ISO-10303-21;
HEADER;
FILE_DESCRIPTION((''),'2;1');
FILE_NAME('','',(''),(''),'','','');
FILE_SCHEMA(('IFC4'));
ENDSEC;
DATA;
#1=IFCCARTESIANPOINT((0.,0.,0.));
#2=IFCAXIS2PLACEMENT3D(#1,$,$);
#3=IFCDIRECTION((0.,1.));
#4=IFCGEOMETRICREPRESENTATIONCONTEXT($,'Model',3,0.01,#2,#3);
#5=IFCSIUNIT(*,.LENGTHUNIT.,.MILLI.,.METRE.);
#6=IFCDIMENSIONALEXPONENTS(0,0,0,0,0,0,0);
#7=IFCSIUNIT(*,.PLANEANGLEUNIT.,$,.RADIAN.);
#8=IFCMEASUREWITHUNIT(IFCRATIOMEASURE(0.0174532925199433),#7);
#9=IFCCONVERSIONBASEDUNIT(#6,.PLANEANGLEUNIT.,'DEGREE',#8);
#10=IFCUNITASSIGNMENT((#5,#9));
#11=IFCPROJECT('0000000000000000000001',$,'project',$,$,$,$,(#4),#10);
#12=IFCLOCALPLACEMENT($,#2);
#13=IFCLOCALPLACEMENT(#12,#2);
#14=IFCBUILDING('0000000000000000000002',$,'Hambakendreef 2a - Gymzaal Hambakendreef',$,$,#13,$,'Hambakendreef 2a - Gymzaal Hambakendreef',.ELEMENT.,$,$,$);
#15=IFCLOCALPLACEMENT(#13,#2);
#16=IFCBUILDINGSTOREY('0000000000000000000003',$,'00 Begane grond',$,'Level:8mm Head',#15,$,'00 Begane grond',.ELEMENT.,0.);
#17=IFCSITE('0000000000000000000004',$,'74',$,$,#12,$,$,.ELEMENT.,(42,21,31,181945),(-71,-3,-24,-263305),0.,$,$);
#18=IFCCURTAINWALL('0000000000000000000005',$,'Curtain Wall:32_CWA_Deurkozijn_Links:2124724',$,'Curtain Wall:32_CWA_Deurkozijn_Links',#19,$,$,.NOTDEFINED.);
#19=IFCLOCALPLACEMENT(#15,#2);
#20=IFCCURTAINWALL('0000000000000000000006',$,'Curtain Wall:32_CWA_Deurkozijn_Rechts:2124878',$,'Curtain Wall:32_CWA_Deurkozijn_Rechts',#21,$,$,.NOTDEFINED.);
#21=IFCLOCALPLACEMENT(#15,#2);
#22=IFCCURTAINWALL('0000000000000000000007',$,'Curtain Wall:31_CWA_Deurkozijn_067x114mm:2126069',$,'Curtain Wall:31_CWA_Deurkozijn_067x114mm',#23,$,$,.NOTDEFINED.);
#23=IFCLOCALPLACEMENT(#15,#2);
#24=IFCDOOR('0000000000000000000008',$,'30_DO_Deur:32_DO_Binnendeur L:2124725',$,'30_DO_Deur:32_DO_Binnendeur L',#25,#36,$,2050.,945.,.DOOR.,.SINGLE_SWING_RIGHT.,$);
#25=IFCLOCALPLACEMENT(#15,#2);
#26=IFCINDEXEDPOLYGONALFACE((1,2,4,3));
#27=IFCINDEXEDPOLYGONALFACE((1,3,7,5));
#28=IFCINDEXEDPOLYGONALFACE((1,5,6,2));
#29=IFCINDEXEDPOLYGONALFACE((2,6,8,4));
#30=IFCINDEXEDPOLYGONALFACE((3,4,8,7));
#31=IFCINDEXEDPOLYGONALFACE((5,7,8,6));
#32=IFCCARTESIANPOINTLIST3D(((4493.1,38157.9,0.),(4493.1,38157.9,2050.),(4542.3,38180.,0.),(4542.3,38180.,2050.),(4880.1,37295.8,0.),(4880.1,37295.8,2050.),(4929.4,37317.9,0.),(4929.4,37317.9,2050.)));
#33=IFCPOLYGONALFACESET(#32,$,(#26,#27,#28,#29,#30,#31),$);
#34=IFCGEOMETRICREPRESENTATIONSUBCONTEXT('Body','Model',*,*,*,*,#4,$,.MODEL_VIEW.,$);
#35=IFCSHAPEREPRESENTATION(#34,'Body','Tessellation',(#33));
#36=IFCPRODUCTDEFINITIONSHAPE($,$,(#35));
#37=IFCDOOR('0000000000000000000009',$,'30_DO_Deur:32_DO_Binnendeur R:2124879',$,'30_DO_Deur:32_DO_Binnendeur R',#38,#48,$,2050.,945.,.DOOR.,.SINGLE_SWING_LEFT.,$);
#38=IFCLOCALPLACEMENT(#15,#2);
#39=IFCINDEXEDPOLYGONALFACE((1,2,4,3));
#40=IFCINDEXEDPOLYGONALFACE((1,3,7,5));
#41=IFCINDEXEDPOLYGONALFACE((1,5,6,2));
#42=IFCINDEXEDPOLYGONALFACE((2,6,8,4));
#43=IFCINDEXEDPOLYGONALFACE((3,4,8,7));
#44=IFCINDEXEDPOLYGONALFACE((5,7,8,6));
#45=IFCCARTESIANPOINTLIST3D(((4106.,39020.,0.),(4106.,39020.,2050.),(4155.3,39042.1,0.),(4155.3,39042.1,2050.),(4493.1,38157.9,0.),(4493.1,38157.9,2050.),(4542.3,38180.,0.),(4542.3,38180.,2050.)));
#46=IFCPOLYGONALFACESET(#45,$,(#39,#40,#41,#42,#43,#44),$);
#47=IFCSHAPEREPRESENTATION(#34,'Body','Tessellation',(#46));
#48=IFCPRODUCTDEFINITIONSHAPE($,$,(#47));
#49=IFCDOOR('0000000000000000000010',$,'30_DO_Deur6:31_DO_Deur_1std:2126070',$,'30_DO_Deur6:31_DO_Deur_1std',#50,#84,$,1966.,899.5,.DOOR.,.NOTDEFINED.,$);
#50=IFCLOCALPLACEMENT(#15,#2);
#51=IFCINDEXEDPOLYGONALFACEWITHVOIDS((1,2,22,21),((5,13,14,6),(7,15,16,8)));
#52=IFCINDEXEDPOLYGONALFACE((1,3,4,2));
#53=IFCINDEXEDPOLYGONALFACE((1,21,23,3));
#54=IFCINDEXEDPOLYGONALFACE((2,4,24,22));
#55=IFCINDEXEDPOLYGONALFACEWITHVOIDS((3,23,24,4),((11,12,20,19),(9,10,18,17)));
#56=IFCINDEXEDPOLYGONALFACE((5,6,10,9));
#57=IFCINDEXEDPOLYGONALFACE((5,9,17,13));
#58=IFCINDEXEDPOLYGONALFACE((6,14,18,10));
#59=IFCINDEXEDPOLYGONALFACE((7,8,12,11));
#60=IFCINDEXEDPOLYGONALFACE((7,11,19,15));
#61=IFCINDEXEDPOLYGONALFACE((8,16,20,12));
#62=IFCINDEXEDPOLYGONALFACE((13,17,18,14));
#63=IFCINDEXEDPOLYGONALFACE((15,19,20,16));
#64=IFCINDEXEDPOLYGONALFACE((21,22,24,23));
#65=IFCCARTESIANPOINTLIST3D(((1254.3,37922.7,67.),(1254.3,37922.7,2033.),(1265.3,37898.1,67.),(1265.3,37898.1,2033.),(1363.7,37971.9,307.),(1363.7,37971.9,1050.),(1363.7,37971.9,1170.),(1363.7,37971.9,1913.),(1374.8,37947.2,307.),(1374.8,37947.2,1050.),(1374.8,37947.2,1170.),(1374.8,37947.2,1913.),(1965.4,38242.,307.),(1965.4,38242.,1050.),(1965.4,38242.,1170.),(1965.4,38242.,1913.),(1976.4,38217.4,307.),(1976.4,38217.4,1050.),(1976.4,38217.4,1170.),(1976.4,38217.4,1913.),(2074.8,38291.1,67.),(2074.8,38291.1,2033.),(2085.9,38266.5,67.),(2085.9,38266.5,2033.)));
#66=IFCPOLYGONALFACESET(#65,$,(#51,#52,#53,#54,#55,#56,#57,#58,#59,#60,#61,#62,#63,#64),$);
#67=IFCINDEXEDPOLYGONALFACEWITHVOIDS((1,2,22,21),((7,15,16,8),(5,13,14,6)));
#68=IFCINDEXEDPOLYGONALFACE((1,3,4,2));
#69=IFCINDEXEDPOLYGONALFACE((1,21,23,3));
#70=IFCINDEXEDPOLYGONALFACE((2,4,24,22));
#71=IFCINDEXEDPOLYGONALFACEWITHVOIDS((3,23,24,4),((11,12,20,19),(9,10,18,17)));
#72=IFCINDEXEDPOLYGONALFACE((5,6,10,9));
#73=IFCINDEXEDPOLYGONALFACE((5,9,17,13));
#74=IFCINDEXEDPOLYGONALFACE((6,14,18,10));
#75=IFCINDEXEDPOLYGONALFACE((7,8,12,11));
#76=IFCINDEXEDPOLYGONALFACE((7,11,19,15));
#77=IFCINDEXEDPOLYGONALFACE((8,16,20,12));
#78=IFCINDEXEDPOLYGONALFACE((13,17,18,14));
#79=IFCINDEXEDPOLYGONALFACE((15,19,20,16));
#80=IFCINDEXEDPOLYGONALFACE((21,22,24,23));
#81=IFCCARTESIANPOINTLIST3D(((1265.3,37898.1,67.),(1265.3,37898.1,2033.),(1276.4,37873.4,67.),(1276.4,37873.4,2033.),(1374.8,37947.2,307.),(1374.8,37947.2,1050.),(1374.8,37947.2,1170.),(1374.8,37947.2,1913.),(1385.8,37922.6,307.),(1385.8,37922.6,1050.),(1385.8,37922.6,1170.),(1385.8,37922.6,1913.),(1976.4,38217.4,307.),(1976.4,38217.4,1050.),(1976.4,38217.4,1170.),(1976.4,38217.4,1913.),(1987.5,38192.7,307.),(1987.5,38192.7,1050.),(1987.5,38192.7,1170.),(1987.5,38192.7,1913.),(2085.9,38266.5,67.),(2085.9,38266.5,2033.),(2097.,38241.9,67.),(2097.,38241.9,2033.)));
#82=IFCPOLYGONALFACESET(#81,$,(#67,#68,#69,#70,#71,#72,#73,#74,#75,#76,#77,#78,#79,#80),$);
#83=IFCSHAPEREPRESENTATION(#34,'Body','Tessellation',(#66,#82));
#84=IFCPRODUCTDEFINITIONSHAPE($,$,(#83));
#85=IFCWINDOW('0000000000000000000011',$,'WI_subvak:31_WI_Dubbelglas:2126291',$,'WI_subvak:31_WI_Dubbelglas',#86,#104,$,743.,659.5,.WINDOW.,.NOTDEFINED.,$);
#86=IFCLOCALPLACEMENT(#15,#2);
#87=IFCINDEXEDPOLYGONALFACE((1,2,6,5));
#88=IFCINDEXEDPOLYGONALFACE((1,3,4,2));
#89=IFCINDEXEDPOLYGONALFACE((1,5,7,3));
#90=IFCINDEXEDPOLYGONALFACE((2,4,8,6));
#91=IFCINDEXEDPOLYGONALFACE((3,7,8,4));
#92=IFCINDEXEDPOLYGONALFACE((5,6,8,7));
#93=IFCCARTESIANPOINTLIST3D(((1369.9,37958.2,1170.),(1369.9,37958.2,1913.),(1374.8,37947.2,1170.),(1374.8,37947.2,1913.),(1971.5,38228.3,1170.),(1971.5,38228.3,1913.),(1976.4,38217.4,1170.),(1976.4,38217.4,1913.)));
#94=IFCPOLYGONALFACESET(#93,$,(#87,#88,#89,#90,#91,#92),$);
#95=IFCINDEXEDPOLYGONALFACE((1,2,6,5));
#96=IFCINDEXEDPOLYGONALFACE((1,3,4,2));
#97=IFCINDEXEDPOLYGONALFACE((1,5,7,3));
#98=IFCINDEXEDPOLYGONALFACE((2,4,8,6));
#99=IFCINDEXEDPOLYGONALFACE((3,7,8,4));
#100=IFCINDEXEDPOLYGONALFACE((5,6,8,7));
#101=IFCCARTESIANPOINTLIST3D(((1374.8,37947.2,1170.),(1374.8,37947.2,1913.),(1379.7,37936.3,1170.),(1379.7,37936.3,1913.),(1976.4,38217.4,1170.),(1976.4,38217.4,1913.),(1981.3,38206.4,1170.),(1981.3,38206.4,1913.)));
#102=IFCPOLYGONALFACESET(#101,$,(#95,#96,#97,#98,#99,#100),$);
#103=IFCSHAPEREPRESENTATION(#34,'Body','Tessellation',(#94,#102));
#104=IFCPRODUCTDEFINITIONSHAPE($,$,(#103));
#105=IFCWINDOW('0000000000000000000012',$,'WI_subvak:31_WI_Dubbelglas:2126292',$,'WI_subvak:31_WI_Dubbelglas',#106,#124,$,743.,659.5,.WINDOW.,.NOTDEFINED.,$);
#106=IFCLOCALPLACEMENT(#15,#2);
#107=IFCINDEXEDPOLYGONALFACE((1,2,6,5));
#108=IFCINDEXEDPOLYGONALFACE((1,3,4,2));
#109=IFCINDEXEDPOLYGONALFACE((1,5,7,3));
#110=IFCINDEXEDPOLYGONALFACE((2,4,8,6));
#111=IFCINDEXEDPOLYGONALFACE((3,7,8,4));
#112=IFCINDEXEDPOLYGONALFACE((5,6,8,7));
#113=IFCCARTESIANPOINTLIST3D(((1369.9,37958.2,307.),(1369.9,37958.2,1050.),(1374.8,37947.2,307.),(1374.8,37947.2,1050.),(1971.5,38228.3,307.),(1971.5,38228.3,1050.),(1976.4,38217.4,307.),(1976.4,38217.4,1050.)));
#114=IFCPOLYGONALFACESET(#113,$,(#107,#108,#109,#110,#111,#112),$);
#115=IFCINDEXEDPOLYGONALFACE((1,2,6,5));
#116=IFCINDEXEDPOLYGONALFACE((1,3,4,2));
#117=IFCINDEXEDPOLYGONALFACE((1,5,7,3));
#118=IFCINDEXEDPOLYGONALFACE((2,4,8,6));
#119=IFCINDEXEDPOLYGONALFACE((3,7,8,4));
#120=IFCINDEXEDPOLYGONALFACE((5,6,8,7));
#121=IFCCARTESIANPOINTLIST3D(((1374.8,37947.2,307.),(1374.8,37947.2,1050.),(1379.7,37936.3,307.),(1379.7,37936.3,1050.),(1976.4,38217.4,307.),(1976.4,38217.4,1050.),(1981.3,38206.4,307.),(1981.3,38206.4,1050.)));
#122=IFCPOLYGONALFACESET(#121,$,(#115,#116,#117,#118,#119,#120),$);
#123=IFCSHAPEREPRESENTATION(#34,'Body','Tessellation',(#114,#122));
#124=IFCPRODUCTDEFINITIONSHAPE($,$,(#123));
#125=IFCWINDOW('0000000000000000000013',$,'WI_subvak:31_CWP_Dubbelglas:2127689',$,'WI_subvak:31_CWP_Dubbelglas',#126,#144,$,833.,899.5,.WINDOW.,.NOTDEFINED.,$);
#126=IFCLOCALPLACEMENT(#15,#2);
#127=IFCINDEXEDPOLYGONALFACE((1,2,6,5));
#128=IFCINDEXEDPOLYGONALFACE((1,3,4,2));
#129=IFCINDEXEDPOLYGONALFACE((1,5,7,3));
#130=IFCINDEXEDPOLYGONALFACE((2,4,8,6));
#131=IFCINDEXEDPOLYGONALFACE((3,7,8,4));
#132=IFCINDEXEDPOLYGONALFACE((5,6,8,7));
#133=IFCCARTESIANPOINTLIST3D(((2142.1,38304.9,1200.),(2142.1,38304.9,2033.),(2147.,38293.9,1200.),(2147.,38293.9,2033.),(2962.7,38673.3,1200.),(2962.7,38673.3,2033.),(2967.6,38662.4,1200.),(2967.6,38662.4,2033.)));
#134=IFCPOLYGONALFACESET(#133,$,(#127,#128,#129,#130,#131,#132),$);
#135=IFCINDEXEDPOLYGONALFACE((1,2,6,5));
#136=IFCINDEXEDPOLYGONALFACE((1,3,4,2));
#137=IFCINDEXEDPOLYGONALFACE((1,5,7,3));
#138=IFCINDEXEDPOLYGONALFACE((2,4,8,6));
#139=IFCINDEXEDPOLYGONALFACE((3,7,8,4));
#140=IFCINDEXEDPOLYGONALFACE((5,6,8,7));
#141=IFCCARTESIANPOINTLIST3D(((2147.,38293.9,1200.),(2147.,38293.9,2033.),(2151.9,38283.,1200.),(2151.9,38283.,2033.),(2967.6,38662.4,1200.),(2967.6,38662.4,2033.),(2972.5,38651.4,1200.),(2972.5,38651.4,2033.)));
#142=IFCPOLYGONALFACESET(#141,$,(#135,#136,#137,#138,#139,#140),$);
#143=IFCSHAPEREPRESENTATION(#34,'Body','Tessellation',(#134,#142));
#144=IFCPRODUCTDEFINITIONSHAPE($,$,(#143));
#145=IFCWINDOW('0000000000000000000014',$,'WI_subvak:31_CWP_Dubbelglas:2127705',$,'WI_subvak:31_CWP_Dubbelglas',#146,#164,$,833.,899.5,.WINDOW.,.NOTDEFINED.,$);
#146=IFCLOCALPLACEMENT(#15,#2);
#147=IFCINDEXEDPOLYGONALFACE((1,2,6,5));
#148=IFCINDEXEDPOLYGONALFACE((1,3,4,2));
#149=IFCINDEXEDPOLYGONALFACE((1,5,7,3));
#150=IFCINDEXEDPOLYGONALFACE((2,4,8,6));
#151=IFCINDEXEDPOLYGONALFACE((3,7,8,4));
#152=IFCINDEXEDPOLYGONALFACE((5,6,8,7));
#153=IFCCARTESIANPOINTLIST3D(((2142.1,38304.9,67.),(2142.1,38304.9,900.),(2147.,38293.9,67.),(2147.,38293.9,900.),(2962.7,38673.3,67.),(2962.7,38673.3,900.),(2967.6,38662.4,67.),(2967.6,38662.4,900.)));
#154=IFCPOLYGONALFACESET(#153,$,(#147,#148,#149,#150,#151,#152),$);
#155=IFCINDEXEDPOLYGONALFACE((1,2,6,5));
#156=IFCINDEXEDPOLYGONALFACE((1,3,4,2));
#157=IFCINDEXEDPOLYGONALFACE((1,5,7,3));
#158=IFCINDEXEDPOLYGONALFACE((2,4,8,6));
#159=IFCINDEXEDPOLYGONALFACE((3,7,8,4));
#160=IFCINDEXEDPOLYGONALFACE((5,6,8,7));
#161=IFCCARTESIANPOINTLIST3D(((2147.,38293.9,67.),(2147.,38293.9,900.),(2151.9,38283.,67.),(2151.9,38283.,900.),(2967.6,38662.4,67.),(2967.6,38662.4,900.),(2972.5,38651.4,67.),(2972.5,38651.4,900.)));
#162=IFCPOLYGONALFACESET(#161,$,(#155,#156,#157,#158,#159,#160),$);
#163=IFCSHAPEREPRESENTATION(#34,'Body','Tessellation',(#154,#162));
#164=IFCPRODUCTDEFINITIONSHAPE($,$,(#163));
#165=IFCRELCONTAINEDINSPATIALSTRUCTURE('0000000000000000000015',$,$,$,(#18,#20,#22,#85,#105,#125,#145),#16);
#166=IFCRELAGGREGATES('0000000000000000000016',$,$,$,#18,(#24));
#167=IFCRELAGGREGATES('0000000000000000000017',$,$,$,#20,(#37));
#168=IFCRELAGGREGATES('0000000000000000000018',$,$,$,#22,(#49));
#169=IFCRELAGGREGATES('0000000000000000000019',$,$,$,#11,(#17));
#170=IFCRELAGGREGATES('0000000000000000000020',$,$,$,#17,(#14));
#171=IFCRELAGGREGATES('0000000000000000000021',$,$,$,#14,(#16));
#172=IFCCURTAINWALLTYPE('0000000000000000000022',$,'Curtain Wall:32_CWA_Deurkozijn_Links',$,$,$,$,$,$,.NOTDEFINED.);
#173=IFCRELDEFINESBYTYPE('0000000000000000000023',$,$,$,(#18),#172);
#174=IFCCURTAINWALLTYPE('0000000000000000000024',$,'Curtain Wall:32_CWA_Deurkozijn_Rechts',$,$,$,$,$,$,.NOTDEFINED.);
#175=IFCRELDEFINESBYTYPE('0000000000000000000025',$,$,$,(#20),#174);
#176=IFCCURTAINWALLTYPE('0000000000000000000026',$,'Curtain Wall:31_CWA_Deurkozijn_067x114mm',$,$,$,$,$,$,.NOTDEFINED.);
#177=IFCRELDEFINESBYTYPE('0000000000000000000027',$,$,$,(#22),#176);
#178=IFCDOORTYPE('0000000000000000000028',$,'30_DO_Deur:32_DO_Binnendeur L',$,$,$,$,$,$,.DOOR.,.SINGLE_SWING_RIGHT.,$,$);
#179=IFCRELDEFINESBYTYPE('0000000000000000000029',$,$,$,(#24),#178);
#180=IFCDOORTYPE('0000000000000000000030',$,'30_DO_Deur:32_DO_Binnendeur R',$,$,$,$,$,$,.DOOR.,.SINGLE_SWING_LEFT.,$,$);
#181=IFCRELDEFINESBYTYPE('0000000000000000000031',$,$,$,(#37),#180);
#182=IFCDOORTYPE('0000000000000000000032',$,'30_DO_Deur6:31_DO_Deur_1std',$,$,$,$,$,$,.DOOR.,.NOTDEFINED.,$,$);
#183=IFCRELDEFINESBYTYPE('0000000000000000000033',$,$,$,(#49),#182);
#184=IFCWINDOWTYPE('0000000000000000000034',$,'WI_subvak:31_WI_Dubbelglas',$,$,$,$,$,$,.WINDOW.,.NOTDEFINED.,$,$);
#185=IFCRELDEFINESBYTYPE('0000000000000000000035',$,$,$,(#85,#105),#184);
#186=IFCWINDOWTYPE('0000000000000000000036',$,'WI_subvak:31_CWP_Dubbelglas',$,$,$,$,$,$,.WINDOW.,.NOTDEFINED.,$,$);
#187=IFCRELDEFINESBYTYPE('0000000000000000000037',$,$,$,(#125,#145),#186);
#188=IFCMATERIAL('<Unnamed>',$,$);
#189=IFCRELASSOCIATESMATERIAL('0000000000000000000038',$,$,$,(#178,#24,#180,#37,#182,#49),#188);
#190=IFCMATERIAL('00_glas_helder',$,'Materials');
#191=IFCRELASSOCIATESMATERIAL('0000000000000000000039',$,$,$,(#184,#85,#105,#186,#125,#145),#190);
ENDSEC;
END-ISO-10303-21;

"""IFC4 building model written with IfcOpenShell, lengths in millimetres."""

from ifc_helpers import new_model, entity, si_unit, converted_unit, direction, frame, origin, place, context, subcontext, project, spatial, indexed_curve, outline, extrude, source, transform, mapped, material, type_object, type_shapes, element, aggregate, save


model = new_model("IFC4")

# Units and contexts
model_context = context("Model", 3, precision=0.01, world=origin(), true_north=direction((0.0, 1.0)))
body_context = subcontext(model_context, "Body", "Model", "MODEL_VIEW")
ifc_project = project(units=[si_unit("LENGTHUNIT", "METRE", prefix="MILLI"), converted_unit("PLANEANGLEUNIT", "DEGREE", entity("IfcRatioMeasure", 0.0174532925199433), si_unit("PLANEANGLEUNIT", "RADIAN"), dimensions=[0, 0, 0, 0, 0, 0, 0])], contexts=[model_context])

# Site, building, storey
site_placement = place(None, origin())
site = spatial("IfcSite", under=ifc_project, at=site_placement, Name="74", CompositionType="ELEMENT", RefLatitude=(42, 21, 31, 181945), RefLongitude=(-71, -3, -24, -263305), RefElevation=0.0)
building_placement = place(site_placement, origin())
building = spatial("IfcBuilding", under=site, at=building_placement, Name="Hambakendreef 2a - Gymzaal Hambakendreef", LongName="Hambakendreef 2a - Gymzaal Hambakendreef", CompositionType="ELEMENT")
storey_placement = place(building_placement, origin())
storey = spatial("IfcBuildingStorey", under=building, at=storey_placement, Name="00 Begane grond", ObjectType="Level:8mm Head", LongName="00 Begane grond", CompositionType="ELEMENT", Elevation=0.0)

# Curtain walls
curtain_wall_type_1 = type_object("IfcCurtainWallType", Name="Curtain Wall:32_CWA_Deurkozijn_Links", PredefinedType="NOTDEFINED")
curtain_wall_1_placement = place(storey_placement, origin())
curtain_wall_1 = element("IfcCurtainWall", 1, at=curtain_wall_1_placement, inside=storey, type_object=curtain_wall_type_1, Name="Curtain Wall:32_CWA_Deurkozijn_Links:2124724", ObjectType="Curtain Wall:32_CWA_Deurkozijn_Links", PredefinedType="NOTDEFINED")
curtain_wall_type_2 = type_object("IfcCurtainWallType", Name="Curtain Wall:32_CWA_Deurkozijn_Rechts", PredefinedType="NOTDEFINED")
curtain_wall_2_placement = place(storey_placement, origin())
curtain_wall_2 = element("IfcCurtainWall", 2, at=curtain_wall_2_placement, inside=storey, type_object=curtain_wall_type_2, Name="Curtain Wall:32_CWA_Deurkozijn_Rechts:2124878", ObjectType="Curtain Wall:32_CWA_Deurkozijn_Rechts", PredefinedType="NOTDEFINED")
curtain_wall_type_3 = type_object("IfcCurtainWallType", Name="Curtain Wall:31_CWA_Deurkozijn_067x114mm", PredefinedType="NOTDEFINED")
curtain_wall_3_placement = place(storey_placement, origin())
curtain_wall_3 = element("IfcCurtainWall", 3, at=curtain_wall_3_placement, inside=storey, type_object=curtain_wall_type_3, Name="Curtain Wall:31_CWA_Deurkozijn_067x114mm:2126069", ObjectType="Curtain Wall:31_CWA_Deurkozijn_067x114mm", PredefinedType="NOTDEFINED")

# Doors
ifc_material_1 = material(Name="<Unnamed>")
door_type_1 = type_object("IfcDoorType", Name="30_DO_Deur:32_DO_Binnendeur L", OperationType="SINGLE_SWING_RIGHT", PredefinedType="DOOR", material=ifc_material_1)
shared_shape_1 = source(origin(), body_context, "Body", "SweptSolid", [
    extrude(outline(indexed_curve([(-472.5, -27.0), (472.5, -27.0), (472.5, 27.0), (-472.5, 27.0), (-472.5, -27.0)], self_intersect=False)), frame((0.0, 0.0, 0.0), z_axis=(0.0, 0.0, 1.0), x_axis=(-1.0, 0.0, 0.0)), (0.0, 0.0, 1.0), 2050.0),
])
type_shapes(door_type_1, [shared_shape_1])
door_1_placement = place(curtain_wall_1_placement, frame((4711.2, 37737.9, 0.0), z_axis=(0.0, 0.0, 1.0), x_axis=(-0.40959, 0.91227, 0.0)))
door_1 = element("IfcDoor", 4, at=door_1_placement, type_object=door_type_1, material=ifc_material_1, Name="30_DO_Deur:32_DO_Binnendeur L:2124725", ObjectType="30_DO_Deur:32_DO_Binnendeur L", OperationType="SINGLE_SWING_RIGHT", OverallHeight=2050.0, OverallWidth=945.0, PredefinedType="DOOR", context=body_context, shape_type="MappedRepresentation", body=[
    mapped(shared_shape_1, transform((0.0, 0.0, 0.0), scale=1.0)),
])
aggregate(curtain_wall_1, [door_1])
door_type_2 = type_object("IfcDoorType", Name="30_DO_Deur:32_DO_Binnendeur R", OperationType="SINGLE_SWING_LEFT", PredefinedType="DOOR", material=ifc_material_1)
shared_shape_2 = source(origin(), body_context, "Body", "SweptSolid", [
    extrude(outline(indexed_curve([(-472.5, -27.0), (472.5, -27.0), (472.5, 27.0), (-472.5, 27.0), (-472.5, -27.0)], self_intersect=False)), frame((0.0, 0.0, 0.0), z_axis=(0.0, 0.0, 1.0), x_axis=(-1.0, 0.0, 0.0)), (0.0, 0.0, 1.0), 2050.0),
])
type_shapes(door_type_2, [shared_shape_2])
door_2_placement = place(curtain_wall_2_placement, frame((4324.2, 38600.0, 0.0), z_axis=(0.0, 0.0, 1.0), x_axis=(-0.40959, 0.91227, 0.0)))
door_2 = element("IfcDoor", 5, at=door_2_placement, type_object=door_type_2, material=ifc_material_1, Name="30_DO_Deur:32_DO_Binnendeur R:2124879", ObjectType="30_DO_Deur:32_DO_Binnendeur R", OperationType="SINGLE_SWING_LEFT", OverallHeight=2050.0, OverallWidth=945.0, PredefinedType="DOOR", context=body_context, shape_type="MappedRepresentation", body=[
    mapped(shared_shape_2, transform((0.0, 0.0, 0.0), scale=1.0)),
])
aggregate(curtain_wall_2, [door_2])
door_type_3 = type_object("IfcDoorType", Name="30_DO_Deur6:31_DO_Deur_1std", OperationType="NOTDEFINED", PredefinedType="DOOR", material=ifc_material_1)
shared_shape_3 = source(origin(), body_context, "Body", "SweptSolid", [
    extrude(outline(indexed_curve([(-449.8, -983.0), (449.8, -983.0), (449.8, 983.0), (-449.8, 983.0), (-449.8, -983.0)], self_intersect=False), holes=[indexed_curve([(-329.8, -120.0), (329.7, -120.0), (329.7, -863.0), (-329.8, -863.0), (-329.8, -120.0)], self_intersect=False), indexed_curve([(-329.8, 0.0), (-329.8, 743.0), (329.7, 743.0), (329.7, 0.0), (-329.8, 0.0)], self_intersect=False)]), frame((0.0, 0.0, 983.0), z_axis=(0.0, 1.0, 0.0), x_axis=(1.0, 0.0, 0.0)), (0.0, 0.0, 1.0), 27.0),
    extrude(outline(indexed_curve([(-449.8, -983.0), (449.8, -983.0), (449.8, 983.0), (-449.8, 983.0), (-449.8, -983.0)], self_intersect=False), holes=[indexed_curve([(-329.8, -120.0), (329.8, -120.0), (329.8, -863.0), (-329.8, -863.0), (-329.8, -120.0)], self_intersect=False), indexed_curve([(-329.8, 0.0), (-329.8, 743.0), (329.8, 743.0), (329.8, 0.0), (-329.8, 0.0)], self_intersect=False)]), frame((0.0, -27.0, 983.0), z_axis=(0.0, 1.0, 0.0), x_axis=(1.0, 0.0, 0.0)), (0.0, 0.0, 1.0), 27.0),
])
type_shapes(door_type_3, [shared_shape_3])
door_3_placement = place(curtain_wall_3_placement, frame((1675.6, 38082.3, 67.0), z_axis=(0.0, 0.0, 1.0), x_axis=(0.91227, 0.40959, 0.0)))
door_3 = element("IfcDoor", 6, at=door_3_placement, type_object=door_type_3, material=ifc_material_1, Name="30_DO_Deur6:31_DO_Deur_1std:2126070", ObjectType="30_DO_Deur6:31_DO_Deur_1std", OperationType="NOTDEFINED", OverallHeight=1966.0, OverallWidth=899.5, PredefinedType="DOOR", context=body_context, shape_type="MappedRepresentation", body=[
    mapped(shared_shape_3, transform((0.0, 0.0, 0.0), scale=1.0)),
])
aggregate(curtain_wall_3, [door_3])

# Windows
ifc_material_2 = material(Name="00_glas_helder", Category="Materials")
window_type_1 = type_object("IfcWindowType", Name="WI_subvak:31_WI_Dubbelglas", PartitioningType="NOTDEFINED", PredefinedType="WINDOW", material=ifc_material_2)
shared_shape_4 = source(origin(), body_context, "Body", "SweptSolid", [
    extrude(outline(indexed_curve([(-6.0, -329.8), (6.0, -329.8), (6.0, 329.8), (-6.0, 329.8), (-6.0, -329.8)], self_intersect=False)), frame((0.0, 6.0, 0.0), z_axis=(0.0, 0.0, 1.0), x_axis=(0.0, -1.0, 0.0)), (0.0, 0.0, 1.0), 743.0),
    extrude(outline(indexed_curve([(-6.0, -329.8), (6.0, -329.8), (6.0, 329.8), (-6.0, 329.8), (-6.0, -329.8)], self_intersect=False)), frame((0.0, -6.0, 0.0), z_axis=(0.0, 0.0, 1.0), x_axis=(0.0, -1.0, 0.0)), (0.0, 0.0, 1.0), 743.0),
])
type_shapes(window_type_1, [shared_shape_4])
for number, where, z_axis, x_axis, name in (
    (7, (1675.6, 38082.3, 1170.0), (0.0, 0.0, 1.0), (0.91227, 0.40959, 0.0), "WI_subvak:31_WI_Dubbelglas:2126291"),
    (8, (1675.6, 38082.3, 307.0), (0.0, 0.0, 1.0), (0.91227, 0.40959, 0.0), "WI_subvak:31_WI_Dubbelglas:2126292"),
):
    element("IfcWindow", number, at=place(storey_placement, frame(where, z_axis=z_axis, x_axis=x_axis)), inside=storey, type_object=window_type_1, material=ifc_material_2, Name=name, ObjectType="WI_subvak:31_WI_Dubbelglas", OverallHeight=743.0, OverallWidth=659.5, PartitioningType="NOTDEFINED", PredefinedType="WINDOW", context=body_context, shape_type="MappedRepresentation", body=[
        mapped(shared_shape_4, transform((0.0, 0.0, 0.0), scale=1.0)),
    ])
window_type_2 = type_object("IfcWindowType", Name="WI_subvak:31_CWP_Dubbelglas", PartitioningType="NOTDEFINED", PredefinedType="WINDOW", material=ifc_material_2)
shared_shape_5 = source(origin(), body_context, "Body", "SweptSolid", [
    extrude(outline(indexed_curve([(-6.0, -449.8), (6.0, -449.8), (6.0, 449.8), (-6.0, 449.8), (-6.0, -449.8)], self_intersect=False)), frame((0.0, 6.0, 0.0), z_axis=(0.0, 0.0, 1.0), x_axis=(0.0, -1.0, 0.0)), (0.0, 0.0, 1.0), 833.0),
    extrude(outline(indexed_curve([(-6.0, -449.7), (6.0, -449.7), (6.0, 449.7), (-6.0, 449.7), (-6.0, -449.7)], self_intersect=False)), frame((0.0, -6.0, 0.0), z_axis=(0.0, 0.0, 1.0), x_axis=(0.0, -1.0, 0.0)), (0.0, 0.0, 1.0), 833.0),
])
type_shapes(window_type_2, [shared_shape_5])
for number, where, z_axis, x_axis, name in (
    (9, (2557.3, 38478.2, 1200.0), (0.0, 0.0, 1.0), (0.91227, 0.40959, 0.0), "WI_subvak:31_CWP_Dubbelglas:2127689"),
    (10, (2557.3, 38478.2, 67.0), (0.0, 0.0, 1.0), (0.91227, 0.40959, 0.0), "WI_subvak:31_CWP_Dubbelglas:2127705"),
):
    element("IfcWindow", number, at=place(storey_placement, frame(where, z_axis=z_axis, x_axis=x_axis)), inside=storey, type_object=window_type_2, material=ifc_material_2, Name=name, ObjectType="WI_subvak:31_CWP_Dubbelglas", OverallHeight=833.0, OverallWidth=899.5, PartitioningType="NOTDEFINED", PredefinedType="WINDOW", context=body_context, shape_type="MappedRepresentation", body=[
        mapped(shared_shape_5, transform((0.0, 0.0, 0.0), scale=1.0)),
    ])

save(model, "model.ifc")
